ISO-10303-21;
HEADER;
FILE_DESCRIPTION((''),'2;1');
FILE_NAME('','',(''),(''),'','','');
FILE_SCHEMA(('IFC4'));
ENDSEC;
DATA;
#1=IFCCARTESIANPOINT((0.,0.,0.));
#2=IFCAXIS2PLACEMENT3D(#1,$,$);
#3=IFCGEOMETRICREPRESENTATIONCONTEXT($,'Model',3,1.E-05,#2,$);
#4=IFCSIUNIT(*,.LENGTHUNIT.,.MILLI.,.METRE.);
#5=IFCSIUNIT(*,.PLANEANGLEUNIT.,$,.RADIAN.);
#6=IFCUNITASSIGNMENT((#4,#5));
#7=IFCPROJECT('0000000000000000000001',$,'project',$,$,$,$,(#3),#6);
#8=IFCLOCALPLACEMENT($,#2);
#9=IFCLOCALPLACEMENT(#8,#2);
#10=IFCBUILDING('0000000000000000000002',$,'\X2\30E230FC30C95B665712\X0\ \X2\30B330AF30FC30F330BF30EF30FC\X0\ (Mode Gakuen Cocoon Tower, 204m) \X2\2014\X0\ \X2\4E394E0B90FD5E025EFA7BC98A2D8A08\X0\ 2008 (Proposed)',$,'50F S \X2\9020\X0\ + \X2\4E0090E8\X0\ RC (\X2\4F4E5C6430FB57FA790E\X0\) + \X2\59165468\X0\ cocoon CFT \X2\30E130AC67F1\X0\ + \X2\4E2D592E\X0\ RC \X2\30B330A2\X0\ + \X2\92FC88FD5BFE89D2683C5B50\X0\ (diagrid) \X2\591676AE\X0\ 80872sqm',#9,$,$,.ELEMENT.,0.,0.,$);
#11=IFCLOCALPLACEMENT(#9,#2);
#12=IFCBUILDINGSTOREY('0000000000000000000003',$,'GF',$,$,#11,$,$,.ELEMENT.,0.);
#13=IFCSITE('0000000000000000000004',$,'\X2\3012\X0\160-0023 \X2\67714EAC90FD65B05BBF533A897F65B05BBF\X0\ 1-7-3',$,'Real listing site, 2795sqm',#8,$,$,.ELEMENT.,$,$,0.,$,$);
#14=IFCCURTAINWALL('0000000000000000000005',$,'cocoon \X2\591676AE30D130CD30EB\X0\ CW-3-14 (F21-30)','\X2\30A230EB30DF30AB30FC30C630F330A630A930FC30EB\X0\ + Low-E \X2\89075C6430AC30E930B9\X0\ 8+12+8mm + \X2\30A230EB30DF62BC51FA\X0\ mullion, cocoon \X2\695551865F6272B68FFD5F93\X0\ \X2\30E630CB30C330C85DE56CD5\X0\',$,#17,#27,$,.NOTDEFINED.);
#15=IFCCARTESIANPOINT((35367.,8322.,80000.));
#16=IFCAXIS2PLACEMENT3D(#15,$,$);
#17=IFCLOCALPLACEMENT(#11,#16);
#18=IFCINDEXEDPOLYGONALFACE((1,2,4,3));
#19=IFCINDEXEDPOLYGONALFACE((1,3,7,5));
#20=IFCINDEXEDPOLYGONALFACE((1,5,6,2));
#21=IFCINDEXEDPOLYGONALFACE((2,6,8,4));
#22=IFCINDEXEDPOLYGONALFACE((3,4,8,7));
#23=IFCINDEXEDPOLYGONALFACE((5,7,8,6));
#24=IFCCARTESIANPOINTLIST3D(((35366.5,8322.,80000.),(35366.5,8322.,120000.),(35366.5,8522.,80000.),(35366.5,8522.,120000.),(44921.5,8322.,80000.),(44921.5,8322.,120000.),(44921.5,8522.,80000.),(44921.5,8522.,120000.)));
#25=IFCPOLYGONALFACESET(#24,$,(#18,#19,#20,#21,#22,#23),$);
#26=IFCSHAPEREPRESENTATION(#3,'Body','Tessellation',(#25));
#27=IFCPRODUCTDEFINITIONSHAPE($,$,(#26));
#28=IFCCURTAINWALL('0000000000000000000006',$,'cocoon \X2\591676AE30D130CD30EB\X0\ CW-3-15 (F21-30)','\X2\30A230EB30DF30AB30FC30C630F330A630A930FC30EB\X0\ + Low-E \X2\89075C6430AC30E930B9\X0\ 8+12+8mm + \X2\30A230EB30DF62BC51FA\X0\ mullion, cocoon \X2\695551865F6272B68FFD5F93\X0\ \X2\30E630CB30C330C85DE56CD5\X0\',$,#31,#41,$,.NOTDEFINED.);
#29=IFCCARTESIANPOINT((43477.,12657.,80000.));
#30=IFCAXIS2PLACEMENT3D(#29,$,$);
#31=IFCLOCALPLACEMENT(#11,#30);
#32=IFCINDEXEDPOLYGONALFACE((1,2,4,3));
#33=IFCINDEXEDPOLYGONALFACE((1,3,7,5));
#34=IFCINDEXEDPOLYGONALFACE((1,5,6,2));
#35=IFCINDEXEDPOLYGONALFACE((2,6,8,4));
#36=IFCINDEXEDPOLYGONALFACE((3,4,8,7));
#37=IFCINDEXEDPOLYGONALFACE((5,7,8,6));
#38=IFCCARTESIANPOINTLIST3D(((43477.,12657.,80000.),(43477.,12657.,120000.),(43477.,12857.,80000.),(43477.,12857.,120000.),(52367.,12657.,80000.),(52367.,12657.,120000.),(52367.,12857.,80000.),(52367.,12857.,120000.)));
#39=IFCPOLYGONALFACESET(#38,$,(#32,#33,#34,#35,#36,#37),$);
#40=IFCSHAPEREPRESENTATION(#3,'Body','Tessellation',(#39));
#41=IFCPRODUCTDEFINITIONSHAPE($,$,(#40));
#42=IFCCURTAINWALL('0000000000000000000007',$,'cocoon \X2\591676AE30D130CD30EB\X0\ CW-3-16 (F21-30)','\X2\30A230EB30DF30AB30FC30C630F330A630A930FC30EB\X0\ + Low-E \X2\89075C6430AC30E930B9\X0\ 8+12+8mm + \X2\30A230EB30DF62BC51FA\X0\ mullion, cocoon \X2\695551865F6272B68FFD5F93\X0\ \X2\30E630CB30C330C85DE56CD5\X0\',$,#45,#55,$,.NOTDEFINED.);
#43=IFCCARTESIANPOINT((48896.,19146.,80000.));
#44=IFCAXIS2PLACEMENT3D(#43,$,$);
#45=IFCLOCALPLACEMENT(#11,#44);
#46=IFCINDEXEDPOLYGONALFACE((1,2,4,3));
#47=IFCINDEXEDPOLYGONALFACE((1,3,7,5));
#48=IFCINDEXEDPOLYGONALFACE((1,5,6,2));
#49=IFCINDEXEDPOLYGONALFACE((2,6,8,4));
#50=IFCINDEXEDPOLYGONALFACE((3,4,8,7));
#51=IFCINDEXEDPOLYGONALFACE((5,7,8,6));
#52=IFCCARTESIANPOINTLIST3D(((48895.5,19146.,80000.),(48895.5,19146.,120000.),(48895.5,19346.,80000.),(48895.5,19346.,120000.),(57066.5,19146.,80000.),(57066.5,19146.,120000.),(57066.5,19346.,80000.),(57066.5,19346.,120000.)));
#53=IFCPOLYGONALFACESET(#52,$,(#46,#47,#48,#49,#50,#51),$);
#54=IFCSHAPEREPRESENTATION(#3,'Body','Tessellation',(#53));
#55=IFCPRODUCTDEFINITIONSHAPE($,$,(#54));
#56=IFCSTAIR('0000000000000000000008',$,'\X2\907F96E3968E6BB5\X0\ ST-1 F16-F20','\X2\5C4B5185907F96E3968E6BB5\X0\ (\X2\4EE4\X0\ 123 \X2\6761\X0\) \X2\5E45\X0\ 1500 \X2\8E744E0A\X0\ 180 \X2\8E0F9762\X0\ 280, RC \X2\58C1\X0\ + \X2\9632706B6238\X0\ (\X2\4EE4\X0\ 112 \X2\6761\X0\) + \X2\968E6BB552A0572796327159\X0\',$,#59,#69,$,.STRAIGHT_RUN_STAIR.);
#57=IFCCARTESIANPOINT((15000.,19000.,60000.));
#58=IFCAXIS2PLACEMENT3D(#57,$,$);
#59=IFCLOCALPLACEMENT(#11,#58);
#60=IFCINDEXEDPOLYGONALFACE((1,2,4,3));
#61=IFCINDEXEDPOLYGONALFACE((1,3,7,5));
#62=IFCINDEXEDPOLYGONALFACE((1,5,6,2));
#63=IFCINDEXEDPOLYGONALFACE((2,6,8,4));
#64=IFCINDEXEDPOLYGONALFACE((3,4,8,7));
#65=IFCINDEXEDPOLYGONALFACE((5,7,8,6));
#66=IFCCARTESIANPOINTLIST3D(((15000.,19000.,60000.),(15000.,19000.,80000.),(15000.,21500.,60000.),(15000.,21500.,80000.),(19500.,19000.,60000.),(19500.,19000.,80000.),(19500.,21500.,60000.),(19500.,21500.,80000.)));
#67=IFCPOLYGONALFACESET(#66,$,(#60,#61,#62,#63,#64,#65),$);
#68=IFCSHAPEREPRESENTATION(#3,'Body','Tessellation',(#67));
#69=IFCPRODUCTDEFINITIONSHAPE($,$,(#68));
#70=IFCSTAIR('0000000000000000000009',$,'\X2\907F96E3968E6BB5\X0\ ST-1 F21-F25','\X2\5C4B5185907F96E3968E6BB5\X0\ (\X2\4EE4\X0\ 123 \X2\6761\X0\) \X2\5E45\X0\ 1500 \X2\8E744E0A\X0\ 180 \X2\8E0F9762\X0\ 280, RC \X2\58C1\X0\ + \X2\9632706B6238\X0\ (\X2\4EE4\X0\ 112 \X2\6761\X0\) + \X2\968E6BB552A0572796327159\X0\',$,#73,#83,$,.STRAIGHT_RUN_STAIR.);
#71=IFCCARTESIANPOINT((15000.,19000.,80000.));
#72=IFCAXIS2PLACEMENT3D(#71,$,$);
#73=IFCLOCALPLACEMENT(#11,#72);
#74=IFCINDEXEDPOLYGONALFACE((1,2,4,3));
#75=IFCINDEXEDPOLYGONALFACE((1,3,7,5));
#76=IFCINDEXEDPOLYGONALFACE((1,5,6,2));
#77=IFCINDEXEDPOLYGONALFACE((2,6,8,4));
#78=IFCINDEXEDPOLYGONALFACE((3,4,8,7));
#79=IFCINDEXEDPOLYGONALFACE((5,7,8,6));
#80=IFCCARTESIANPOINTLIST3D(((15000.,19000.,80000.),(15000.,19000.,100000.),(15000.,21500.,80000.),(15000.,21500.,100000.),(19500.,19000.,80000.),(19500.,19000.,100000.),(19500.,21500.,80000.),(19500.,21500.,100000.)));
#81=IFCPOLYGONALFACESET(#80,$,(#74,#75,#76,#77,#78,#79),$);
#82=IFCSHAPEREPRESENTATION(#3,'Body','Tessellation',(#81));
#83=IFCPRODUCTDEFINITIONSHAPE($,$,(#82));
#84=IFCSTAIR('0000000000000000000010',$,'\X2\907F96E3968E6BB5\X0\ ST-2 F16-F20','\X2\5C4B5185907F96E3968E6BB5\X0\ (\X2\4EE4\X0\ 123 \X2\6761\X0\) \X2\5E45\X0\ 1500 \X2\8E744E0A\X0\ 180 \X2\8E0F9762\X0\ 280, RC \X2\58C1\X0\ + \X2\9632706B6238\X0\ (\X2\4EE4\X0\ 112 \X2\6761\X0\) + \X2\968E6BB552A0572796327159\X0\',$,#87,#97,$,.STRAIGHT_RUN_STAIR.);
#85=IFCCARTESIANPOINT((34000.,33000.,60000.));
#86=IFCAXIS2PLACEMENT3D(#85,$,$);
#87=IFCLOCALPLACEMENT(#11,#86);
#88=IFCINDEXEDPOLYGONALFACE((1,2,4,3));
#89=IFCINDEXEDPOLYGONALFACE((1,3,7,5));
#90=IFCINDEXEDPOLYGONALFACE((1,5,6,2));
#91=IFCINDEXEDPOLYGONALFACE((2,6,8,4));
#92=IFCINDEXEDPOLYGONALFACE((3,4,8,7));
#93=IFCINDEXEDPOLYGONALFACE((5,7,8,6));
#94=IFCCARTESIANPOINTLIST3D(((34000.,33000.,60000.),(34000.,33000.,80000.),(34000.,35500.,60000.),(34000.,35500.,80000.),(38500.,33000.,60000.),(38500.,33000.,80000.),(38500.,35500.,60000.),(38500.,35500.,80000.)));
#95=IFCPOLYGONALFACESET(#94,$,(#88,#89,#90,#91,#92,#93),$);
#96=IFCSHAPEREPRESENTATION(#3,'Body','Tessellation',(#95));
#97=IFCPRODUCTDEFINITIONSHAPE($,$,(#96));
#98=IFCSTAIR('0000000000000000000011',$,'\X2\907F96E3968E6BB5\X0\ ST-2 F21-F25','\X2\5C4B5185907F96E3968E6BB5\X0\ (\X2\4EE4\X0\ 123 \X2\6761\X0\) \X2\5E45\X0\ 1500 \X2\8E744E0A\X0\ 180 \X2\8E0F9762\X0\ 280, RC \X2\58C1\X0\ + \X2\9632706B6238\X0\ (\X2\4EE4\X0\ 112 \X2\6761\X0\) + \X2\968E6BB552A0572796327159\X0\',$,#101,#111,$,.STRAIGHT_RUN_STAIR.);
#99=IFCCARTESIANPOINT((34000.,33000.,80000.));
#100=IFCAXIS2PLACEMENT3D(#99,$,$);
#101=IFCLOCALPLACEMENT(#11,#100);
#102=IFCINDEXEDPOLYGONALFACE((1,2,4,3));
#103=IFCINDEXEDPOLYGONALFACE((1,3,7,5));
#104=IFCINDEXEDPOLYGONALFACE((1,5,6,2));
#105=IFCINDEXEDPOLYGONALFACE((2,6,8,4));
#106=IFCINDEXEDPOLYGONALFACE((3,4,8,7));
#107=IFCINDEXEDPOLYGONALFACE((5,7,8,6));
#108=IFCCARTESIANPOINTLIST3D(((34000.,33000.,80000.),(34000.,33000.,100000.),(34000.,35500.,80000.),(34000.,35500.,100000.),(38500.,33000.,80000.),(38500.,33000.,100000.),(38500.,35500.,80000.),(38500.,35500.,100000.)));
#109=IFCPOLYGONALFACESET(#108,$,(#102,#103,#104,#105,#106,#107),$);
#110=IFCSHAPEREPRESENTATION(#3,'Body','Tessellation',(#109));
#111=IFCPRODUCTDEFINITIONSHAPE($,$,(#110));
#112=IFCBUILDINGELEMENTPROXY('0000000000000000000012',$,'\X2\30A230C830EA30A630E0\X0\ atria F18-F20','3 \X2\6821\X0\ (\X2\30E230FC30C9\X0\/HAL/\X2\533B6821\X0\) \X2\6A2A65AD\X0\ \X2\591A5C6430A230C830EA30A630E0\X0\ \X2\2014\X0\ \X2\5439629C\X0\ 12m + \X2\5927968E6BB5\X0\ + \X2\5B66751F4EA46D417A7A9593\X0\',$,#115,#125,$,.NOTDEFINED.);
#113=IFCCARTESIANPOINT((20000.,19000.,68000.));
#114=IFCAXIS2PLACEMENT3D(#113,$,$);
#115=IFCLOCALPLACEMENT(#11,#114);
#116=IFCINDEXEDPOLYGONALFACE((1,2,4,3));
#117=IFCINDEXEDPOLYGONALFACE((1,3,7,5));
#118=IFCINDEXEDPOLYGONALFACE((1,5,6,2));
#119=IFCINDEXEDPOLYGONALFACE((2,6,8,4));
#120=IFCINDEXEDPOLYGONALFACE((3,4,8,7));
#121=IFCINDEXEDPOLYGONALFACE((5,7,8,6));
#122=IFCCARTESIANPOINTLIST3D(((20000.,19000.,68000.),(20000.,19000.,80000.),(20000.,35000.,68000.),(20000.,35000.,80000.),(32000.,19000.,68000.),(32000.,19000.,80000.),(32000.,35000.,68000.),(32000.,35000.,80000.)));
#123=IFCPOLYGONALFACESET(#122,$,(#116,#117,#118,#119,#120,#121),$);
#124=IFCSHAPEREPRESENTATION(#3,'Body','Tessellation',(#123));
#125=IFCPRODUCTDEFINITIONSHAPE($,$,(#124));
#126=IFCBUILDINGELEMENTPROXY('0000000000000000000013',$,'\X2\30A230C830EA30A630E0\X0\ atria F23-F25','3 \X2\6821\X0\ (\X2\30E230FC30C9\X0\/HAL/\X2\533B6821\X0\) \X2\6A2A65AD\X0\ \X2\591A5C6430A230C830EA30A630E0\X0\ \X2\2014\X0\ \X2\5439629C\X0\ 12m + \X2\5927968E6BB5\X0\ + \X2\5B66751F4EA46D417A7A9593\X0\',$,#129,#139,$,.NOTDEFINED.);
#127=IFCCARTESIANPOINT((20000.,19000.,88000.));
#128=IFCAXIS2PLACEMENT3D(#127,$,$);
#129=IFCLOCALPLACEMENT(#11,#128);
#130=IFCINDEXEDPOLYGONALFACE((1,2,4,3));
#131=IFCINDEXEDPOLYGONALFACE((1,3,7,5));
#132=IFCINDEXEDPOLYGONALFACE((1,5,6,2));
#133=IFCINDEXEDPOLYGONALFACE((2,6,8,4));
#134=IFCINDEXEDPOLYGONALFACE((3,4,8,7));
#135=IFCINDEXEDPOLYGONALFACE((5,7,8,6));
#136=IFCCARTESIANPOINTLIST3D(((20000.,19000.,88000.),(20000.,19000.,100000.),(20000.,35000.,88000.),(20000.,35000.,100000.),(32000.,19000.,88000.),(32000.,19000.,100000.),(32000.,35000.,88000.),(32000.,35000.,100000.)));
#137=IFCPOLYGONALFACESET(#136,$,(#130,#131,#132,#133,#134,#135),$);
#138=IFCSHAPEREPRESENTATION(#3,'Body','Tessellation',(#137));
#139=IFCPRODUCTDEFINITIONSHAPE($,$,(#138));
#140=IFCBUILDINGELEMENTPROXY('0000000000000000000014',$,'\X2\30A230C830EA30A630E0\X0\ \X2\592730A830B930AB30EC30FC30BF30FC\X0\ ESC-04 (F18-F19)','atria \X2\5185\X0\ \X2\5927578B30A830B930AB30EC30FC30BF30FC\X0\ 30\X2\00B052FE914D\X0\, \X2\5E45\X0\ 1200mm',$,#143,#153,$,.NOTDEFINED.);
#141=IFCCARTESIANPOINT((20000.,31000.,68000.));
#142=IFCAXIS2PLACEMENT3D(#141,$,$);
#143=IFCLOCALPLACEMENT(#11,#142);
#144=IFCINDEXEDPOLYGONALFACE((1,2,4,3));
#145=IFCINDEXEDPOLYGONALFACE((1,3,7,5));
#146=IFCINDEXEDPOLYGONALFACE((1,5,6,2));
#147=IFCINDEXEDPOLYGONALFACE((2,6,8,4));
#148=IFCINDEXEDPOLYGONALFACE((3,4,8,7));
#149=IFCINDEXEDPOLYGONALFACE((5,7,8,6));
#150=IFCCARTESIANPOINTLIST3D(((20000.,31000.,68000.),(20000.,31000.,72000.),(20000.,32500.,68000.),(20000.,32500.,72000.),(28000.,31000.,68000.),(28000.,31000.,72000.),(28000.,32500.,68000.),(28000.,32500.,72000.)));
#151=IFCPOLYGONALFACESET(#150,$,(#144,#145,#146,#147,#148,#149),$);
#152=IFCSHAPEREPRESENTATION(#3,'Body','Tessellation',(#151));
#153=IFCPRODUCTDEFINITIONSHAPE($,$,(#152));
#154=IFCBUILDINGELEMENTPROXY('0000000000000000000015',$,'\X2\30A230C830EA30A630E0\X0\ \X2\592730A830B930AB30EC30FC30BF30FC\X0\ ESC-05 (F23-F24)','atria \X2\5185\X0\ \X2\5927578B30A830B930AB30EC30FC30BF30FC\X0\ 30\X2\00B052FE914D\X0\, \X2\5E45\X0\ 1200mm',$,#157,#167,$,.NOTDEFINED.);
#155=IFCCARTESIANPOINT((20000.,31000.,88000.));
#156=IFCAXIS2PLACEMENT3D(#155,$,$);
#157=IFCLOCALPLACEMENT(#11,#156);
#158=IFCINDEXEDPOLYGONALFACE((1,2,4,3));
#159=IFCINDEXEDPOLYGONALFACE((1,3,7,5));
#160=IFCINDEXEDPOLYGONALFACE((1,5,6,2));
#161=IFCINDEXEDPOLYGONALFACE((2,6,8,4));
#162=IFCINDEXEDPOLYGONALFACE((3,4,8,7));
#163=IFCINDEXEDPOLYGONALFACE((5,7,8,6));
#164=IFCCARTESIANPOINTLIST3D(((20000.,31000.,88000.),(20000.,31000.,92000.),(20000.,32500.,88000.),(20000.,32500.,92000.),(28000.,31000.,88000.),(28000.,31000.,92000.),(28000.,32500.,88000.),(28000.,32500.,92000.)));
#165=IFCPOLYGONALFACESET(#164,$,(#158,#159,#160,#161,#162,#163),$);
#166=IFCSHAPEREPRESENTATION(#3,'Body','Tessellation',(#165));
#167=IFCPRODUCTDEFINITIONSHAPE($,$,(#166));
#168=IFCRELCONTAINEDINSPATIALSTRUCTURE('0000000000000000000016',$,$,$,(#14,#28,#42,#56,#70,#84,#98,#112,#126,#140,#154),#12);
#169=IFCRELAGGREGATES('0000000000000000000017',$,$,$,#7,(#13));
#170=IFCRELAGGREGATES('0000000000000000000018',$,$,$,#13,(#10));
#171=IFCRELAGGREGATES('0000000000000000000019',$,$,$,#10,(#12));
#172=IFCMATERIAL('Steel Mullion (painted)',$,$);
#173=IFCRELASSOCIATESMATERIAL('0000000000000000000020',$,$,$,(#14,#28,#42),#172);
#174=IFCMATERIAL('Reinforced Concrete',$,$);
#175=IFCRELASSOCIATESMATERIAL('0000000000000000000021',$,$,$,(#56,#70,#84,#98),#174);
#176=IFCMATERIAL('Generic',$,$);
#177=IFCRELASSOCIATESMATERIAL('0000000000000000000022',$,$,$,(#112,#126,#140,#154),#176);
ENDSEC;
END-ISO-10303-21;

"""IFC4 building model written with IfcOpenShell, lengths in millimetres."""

from ifc_helpers import new_model, si_unit, frame, frame_2d, origin, place, context, project, spatial, rectangle, extrude, material, element, save


model = new_model("IFC4")

# Units and contexts
model_context = context("Model", 3, precision=1e-05, world=origin())
ifc_project = project(units=[si_unit("LENGTHUNIT", "METRE", prefix="MILLI"), si_unit("PLANEANGLEUNIT", "RADIAN")], contexts=[model_context])

# Site, building, storey
site_placement = place(None, origin())
site = spatial("IfcSite", under=ifc_project, at=site_placement, Name="〒160-0023 東京都新宿区西新宿 1-7-3", ObjectType="Real listing site, 2795sqm", CompositionType="ELEMENT", RefElevation=0.0)
building_placement = place(site_placement, origin())
building = spatial("IfcBuilding", under=site, at=building_placement, Name="モード学園 コクーンタワー (Mode Gakuen Cocoon Tower, 204m) — 丹下都市建築設計 2008 (Proposed)", ObjectType="50F S 造 + 一部 RC (低層・基礎) + 外周 cocoon CFT メガ柱 + 中央 RC コア + 鋼製対角格子 (diagrid) 外皮 80872sqm", CompositionType="ELEMENT", ElevationOfRefHeight=0.0, ElevationOfTerrain=0.0)
storey_placement = place(building_placement, origin())
storey = spatial("IfcBuildingStorey", under=building, at=storey_placement, Name="GF", CompositionType="ELEMENT", Elevation=0.0)

# Shared definitions
ifc_material_1 = material(Name="Generic")

# Curtain walls
ifc_material_2 = material(Name="Steel Mullion (painted)")
curtain_wall_1_placement = place(storey_placement, frame((35367.0, 8322.0, 80000.0)))
element("IfcCurtainWall", 1, at=curtain_wall_1_placement, inside=storey, material=ifc_material_2, Name="cocoon 外皮パネル CW-3-14 (F21-30)", Description="アルミカーテンウォール + Low-E 複層ガラス 8+12+8mm + アルミ押出 mullion, cocoon 楕円形状追従 ユニット工法", PredefinedType="NOTDEFINED", context=model_context, shape_type="SweptSolid", body=[
    extrude(rectangle(XDim=9555.0, YDim=200.0, at=frame_2d((4777.0, 100.0))), frame((35367.0, 8322.0, 80000.0)), (0.0, 0.0, 1.0), 40000.0),
])
curtain_wall_2_placement = place(storey_placement, frame((43477.0, 12657.0, 80000.0)))
element("IfcCurtainWall", 2, at=curtain_wall_2_placement, inside=storey, material=ifc_material_2, Name="cocoon 外皮パネル CW-3-15 (F21-30)", Description="アルミカーテンウォール + Low-E 複層ガラス 8+12+8mm + アルミ押出 mullion, cocoon 楕円形状追従 ユニット工法", PredefinedType="NOTDEFINED", context=model_context, shape_type="SweptSolid", body=[
    extrude(rectangle(XDim=8890.0, YDim=200.0, at=frame_2d((4445.0, 100.0))), frame((43477.0, 12657.0, 80000.0)), (0.0, 0.0, 1.0), 40000.0),
])
curtain_wall_3_placement = place(storey_placement, frame((48896.0, 19146.0, 80000.0)))
element("IfcCurtainWall", 3, at=curtain_wall_3_placement, inside=storey, material=ifc_material_2, Name="cocoon 外皮パネル CW-3-16 (F21-30)", Description="アルミカーテンウォール + Low-E 複層ガラス 8+12+8mm + アルミ押出 mullion, cocoon 楕円形状追従 ユニット工法", PredefinedType="NOTDEFINED", context=model_context, shape_type="SweptSolid", body=[
    extrude(rectangle(XDim=8171.0, YDim=200.0, at=frame_2d((4085.0, 100.0))), frame((48896.0, 19146.0, 80000.0)), (0.0, 0.0, 1.0), 40000.0),
])

# Stairs
ifc_material_3 = material(Name="Reinforced Concrete")
stair_1_placement = place(storey_placement, frame((15000.0, 19000.0, 60000.0)))
element("IfcStair", 4, at=stair_1_placement, inside=storey, material=ifc_material_3, Name="避難階段 ST-1 F16-F20", Description="屋内避難階段 (令 123 条) 幅 1500 蹴上 180 踏面 280, RC 壁 + 防火戸 (令 112 条) + 階段加圧防煙", PredefinedType="STRAIGHT_RUN_STAIR", context=model_context, shape_type="SweptSolid", body=[
    extrude(rectangle(XDim=4500.0, YDim=2500.0, at=frame_2d((2250.0, 1250.0))), frame((15000.0, 19000.0, 60000.0)), (0.0, 0.0, 1.0), 20000.0),
])
stair_2_placement = place(storey_placement, frame((15000.0, 19000.0, 80000.0)))
element("IfcStair", 5, at=stair_2_placement, inside=storey, material=ifc_material_3, Name="避難階段 ST-1 F21-F25", Description="屋内避難階段 (令 123 条) 幅 1500 蹴上 180 踏面 280, RC 壁 + 防火戸 (令 112 条) + 階段加圧防煙", PredefinedType="STRAIGHT_RUN_STAIR", context=model_context, shape_type="SweptSolid", body=[
    extrude(rectangle(XDim=4500.0, YDim=2500.0, at=frame_2d((2250.0, 1250.0))), frame((15000.0, 19000.0, 80000.0)), (0.0, 0.0, 1.0), 20000.0),
])
stair_3_placement = place(storey_placement, frame((34000.0, 33000.0, 60000.0)))
element("IfcStair", 6, at=stair_3_placement, inside=storey, material=ifc_material_3, Name="避難階段 ST-2 F16-F20", Description="屋内避難階段 (令 123 条) 幅 1500 蹴上 180 踏面 280, RC 壁 + 防火戸 (令 112 条) + 階段加圧防煙", PredefinedType="STRAIGHT_RUN_STAIR", context=model_context, shape_type="SweptSolid", body=[
    extrude(rectangle(XDim=4500.0, YDim=2500.0, at=frame_2d((2250.0, 1250.0))), frame((34000.0, 33000.0, 60000.0)), (0.0, 0.0, 1.0), 20000.0),
])
stair_4_placement = place(storey_placement, frame((34000.0, 33000.0, 80000.0)))
element("IfcStair", 7, at=stair_4_placement, inside=storey, material=ifc_material_3, Name="避難階段 ST-2 F21-F25", Description="屋内避難階段 (令 123 条) 幅 1500 蹴上 180 踏面 280, RC 壁 + 防火戸 (令 112 条) + 階段加圧防煙", PredefinedType="STRAIGHT_RUN_STAIR", context=model_context, shape_type="SweptSolid", body=[
    extrude(rectangle(XDim=4500.0, YDim=2500.0, at=frame_2d((2250.0, 1250.0))), frame((34000.0, 33000.0, 80000.0)), (0.0, 0.0, 1.0), 20000.0),
])

# Building element proxies
proxy_1_placement = place(storey_placement, frame((20000.0, 19000.0, 68000.0)))
element("IfcBuildingElementProxy", 8, at=proxy_1_placement, inside=storey, material=ifc_material_1, Name="アトリウム atria F18-F20", Description="3 校 (モード/HAL/医校) 横断 多層アトリウム — 吹抜 12m + 大階段 + 学生交流空間", PredefinedType="NOTDEFINED", context=model_context, shape_type="SweptSolid", body=[
    extrude(rectangle(XDim=12000.0, YDim=16000.0, at=frame_2d((6000.0, 8000.0))), frame((20000.0, 19000.0, 68000.0)), (0.0, 0.0, 1.0), 12000.0),
])
proxy_2_placement = place(storey_placement, frame((20000.0, 19000.0, 88000.0)))
element("IfcBuildingElementProxy", 9, at=proxy_2_placement, inside=storey, material=ifc_material_1, Name="アトリウム atria F23-F25", Description="3 校 (モード/HAL/医校) 横断 多層アトリウム — 吹抜 12m + 大階段 + 学生交流空間", PredefinedType="NOTDEFINED", context=model_context, shape_type="SweptSolid", body=[
    extrude(rectangle(XDim=12000.0, YDim=16000.0, at=frame_2d((6000.0, 8000.0))), frame((20000.0, 19000.0, 88000.0)), (0.0, 0.0, 1.0), 12000.0),
])
proxy_3_placement = place(storey_placement, frame((20000.0, 31000.0, 68000.0)))
element("IfcBuildingElementProxy", 10, at=proxy_3_placement, inside=storey, material=ifc_material_1, Name="アトリウム 大エスカレーター ESC-04 (F18-F19)", Description="atria 内 大型エスカレーター 30°勾配, 幅 1200mm", PredefinedType="NOTDEFINED", context=model_context, shape_type="SweptSolid", body=[
    extrude(rectangle(XDim=8000.0, YDim=1500.0, at=frame_2d((4000.0, 750.0))), frame((20000.0, 31000.0, 68000.0)), (0.0, 0.0, 1.0), 4000.0),
])
proxy_4_placement = place(storey_placement, frame((20000.0, 31000.0, 88000.0)))
element("IfcBuildingElementProxy", 11, at=proxy_4_placement, inside=storey, material=ifc_material_1, Name="アトリウム 大エスカレーター ESC-05 (F23-F24)", Description="atria 内 大型エスカレーター 30°勾配, 幅 1200mm", PredefinedType="NOTDEFINED", context=model_context, shape_type="SweptSolid", body=[
    extrude(rectangle(XDim=8000.0, YDim=1500.0, at=frame_2d((4000.0, 750.0))), frame((20000.0, 31000.0, 88000.0)), (0.0, 0.0, 1.0), 4000.0),
])

save(model, "model.ifc")
